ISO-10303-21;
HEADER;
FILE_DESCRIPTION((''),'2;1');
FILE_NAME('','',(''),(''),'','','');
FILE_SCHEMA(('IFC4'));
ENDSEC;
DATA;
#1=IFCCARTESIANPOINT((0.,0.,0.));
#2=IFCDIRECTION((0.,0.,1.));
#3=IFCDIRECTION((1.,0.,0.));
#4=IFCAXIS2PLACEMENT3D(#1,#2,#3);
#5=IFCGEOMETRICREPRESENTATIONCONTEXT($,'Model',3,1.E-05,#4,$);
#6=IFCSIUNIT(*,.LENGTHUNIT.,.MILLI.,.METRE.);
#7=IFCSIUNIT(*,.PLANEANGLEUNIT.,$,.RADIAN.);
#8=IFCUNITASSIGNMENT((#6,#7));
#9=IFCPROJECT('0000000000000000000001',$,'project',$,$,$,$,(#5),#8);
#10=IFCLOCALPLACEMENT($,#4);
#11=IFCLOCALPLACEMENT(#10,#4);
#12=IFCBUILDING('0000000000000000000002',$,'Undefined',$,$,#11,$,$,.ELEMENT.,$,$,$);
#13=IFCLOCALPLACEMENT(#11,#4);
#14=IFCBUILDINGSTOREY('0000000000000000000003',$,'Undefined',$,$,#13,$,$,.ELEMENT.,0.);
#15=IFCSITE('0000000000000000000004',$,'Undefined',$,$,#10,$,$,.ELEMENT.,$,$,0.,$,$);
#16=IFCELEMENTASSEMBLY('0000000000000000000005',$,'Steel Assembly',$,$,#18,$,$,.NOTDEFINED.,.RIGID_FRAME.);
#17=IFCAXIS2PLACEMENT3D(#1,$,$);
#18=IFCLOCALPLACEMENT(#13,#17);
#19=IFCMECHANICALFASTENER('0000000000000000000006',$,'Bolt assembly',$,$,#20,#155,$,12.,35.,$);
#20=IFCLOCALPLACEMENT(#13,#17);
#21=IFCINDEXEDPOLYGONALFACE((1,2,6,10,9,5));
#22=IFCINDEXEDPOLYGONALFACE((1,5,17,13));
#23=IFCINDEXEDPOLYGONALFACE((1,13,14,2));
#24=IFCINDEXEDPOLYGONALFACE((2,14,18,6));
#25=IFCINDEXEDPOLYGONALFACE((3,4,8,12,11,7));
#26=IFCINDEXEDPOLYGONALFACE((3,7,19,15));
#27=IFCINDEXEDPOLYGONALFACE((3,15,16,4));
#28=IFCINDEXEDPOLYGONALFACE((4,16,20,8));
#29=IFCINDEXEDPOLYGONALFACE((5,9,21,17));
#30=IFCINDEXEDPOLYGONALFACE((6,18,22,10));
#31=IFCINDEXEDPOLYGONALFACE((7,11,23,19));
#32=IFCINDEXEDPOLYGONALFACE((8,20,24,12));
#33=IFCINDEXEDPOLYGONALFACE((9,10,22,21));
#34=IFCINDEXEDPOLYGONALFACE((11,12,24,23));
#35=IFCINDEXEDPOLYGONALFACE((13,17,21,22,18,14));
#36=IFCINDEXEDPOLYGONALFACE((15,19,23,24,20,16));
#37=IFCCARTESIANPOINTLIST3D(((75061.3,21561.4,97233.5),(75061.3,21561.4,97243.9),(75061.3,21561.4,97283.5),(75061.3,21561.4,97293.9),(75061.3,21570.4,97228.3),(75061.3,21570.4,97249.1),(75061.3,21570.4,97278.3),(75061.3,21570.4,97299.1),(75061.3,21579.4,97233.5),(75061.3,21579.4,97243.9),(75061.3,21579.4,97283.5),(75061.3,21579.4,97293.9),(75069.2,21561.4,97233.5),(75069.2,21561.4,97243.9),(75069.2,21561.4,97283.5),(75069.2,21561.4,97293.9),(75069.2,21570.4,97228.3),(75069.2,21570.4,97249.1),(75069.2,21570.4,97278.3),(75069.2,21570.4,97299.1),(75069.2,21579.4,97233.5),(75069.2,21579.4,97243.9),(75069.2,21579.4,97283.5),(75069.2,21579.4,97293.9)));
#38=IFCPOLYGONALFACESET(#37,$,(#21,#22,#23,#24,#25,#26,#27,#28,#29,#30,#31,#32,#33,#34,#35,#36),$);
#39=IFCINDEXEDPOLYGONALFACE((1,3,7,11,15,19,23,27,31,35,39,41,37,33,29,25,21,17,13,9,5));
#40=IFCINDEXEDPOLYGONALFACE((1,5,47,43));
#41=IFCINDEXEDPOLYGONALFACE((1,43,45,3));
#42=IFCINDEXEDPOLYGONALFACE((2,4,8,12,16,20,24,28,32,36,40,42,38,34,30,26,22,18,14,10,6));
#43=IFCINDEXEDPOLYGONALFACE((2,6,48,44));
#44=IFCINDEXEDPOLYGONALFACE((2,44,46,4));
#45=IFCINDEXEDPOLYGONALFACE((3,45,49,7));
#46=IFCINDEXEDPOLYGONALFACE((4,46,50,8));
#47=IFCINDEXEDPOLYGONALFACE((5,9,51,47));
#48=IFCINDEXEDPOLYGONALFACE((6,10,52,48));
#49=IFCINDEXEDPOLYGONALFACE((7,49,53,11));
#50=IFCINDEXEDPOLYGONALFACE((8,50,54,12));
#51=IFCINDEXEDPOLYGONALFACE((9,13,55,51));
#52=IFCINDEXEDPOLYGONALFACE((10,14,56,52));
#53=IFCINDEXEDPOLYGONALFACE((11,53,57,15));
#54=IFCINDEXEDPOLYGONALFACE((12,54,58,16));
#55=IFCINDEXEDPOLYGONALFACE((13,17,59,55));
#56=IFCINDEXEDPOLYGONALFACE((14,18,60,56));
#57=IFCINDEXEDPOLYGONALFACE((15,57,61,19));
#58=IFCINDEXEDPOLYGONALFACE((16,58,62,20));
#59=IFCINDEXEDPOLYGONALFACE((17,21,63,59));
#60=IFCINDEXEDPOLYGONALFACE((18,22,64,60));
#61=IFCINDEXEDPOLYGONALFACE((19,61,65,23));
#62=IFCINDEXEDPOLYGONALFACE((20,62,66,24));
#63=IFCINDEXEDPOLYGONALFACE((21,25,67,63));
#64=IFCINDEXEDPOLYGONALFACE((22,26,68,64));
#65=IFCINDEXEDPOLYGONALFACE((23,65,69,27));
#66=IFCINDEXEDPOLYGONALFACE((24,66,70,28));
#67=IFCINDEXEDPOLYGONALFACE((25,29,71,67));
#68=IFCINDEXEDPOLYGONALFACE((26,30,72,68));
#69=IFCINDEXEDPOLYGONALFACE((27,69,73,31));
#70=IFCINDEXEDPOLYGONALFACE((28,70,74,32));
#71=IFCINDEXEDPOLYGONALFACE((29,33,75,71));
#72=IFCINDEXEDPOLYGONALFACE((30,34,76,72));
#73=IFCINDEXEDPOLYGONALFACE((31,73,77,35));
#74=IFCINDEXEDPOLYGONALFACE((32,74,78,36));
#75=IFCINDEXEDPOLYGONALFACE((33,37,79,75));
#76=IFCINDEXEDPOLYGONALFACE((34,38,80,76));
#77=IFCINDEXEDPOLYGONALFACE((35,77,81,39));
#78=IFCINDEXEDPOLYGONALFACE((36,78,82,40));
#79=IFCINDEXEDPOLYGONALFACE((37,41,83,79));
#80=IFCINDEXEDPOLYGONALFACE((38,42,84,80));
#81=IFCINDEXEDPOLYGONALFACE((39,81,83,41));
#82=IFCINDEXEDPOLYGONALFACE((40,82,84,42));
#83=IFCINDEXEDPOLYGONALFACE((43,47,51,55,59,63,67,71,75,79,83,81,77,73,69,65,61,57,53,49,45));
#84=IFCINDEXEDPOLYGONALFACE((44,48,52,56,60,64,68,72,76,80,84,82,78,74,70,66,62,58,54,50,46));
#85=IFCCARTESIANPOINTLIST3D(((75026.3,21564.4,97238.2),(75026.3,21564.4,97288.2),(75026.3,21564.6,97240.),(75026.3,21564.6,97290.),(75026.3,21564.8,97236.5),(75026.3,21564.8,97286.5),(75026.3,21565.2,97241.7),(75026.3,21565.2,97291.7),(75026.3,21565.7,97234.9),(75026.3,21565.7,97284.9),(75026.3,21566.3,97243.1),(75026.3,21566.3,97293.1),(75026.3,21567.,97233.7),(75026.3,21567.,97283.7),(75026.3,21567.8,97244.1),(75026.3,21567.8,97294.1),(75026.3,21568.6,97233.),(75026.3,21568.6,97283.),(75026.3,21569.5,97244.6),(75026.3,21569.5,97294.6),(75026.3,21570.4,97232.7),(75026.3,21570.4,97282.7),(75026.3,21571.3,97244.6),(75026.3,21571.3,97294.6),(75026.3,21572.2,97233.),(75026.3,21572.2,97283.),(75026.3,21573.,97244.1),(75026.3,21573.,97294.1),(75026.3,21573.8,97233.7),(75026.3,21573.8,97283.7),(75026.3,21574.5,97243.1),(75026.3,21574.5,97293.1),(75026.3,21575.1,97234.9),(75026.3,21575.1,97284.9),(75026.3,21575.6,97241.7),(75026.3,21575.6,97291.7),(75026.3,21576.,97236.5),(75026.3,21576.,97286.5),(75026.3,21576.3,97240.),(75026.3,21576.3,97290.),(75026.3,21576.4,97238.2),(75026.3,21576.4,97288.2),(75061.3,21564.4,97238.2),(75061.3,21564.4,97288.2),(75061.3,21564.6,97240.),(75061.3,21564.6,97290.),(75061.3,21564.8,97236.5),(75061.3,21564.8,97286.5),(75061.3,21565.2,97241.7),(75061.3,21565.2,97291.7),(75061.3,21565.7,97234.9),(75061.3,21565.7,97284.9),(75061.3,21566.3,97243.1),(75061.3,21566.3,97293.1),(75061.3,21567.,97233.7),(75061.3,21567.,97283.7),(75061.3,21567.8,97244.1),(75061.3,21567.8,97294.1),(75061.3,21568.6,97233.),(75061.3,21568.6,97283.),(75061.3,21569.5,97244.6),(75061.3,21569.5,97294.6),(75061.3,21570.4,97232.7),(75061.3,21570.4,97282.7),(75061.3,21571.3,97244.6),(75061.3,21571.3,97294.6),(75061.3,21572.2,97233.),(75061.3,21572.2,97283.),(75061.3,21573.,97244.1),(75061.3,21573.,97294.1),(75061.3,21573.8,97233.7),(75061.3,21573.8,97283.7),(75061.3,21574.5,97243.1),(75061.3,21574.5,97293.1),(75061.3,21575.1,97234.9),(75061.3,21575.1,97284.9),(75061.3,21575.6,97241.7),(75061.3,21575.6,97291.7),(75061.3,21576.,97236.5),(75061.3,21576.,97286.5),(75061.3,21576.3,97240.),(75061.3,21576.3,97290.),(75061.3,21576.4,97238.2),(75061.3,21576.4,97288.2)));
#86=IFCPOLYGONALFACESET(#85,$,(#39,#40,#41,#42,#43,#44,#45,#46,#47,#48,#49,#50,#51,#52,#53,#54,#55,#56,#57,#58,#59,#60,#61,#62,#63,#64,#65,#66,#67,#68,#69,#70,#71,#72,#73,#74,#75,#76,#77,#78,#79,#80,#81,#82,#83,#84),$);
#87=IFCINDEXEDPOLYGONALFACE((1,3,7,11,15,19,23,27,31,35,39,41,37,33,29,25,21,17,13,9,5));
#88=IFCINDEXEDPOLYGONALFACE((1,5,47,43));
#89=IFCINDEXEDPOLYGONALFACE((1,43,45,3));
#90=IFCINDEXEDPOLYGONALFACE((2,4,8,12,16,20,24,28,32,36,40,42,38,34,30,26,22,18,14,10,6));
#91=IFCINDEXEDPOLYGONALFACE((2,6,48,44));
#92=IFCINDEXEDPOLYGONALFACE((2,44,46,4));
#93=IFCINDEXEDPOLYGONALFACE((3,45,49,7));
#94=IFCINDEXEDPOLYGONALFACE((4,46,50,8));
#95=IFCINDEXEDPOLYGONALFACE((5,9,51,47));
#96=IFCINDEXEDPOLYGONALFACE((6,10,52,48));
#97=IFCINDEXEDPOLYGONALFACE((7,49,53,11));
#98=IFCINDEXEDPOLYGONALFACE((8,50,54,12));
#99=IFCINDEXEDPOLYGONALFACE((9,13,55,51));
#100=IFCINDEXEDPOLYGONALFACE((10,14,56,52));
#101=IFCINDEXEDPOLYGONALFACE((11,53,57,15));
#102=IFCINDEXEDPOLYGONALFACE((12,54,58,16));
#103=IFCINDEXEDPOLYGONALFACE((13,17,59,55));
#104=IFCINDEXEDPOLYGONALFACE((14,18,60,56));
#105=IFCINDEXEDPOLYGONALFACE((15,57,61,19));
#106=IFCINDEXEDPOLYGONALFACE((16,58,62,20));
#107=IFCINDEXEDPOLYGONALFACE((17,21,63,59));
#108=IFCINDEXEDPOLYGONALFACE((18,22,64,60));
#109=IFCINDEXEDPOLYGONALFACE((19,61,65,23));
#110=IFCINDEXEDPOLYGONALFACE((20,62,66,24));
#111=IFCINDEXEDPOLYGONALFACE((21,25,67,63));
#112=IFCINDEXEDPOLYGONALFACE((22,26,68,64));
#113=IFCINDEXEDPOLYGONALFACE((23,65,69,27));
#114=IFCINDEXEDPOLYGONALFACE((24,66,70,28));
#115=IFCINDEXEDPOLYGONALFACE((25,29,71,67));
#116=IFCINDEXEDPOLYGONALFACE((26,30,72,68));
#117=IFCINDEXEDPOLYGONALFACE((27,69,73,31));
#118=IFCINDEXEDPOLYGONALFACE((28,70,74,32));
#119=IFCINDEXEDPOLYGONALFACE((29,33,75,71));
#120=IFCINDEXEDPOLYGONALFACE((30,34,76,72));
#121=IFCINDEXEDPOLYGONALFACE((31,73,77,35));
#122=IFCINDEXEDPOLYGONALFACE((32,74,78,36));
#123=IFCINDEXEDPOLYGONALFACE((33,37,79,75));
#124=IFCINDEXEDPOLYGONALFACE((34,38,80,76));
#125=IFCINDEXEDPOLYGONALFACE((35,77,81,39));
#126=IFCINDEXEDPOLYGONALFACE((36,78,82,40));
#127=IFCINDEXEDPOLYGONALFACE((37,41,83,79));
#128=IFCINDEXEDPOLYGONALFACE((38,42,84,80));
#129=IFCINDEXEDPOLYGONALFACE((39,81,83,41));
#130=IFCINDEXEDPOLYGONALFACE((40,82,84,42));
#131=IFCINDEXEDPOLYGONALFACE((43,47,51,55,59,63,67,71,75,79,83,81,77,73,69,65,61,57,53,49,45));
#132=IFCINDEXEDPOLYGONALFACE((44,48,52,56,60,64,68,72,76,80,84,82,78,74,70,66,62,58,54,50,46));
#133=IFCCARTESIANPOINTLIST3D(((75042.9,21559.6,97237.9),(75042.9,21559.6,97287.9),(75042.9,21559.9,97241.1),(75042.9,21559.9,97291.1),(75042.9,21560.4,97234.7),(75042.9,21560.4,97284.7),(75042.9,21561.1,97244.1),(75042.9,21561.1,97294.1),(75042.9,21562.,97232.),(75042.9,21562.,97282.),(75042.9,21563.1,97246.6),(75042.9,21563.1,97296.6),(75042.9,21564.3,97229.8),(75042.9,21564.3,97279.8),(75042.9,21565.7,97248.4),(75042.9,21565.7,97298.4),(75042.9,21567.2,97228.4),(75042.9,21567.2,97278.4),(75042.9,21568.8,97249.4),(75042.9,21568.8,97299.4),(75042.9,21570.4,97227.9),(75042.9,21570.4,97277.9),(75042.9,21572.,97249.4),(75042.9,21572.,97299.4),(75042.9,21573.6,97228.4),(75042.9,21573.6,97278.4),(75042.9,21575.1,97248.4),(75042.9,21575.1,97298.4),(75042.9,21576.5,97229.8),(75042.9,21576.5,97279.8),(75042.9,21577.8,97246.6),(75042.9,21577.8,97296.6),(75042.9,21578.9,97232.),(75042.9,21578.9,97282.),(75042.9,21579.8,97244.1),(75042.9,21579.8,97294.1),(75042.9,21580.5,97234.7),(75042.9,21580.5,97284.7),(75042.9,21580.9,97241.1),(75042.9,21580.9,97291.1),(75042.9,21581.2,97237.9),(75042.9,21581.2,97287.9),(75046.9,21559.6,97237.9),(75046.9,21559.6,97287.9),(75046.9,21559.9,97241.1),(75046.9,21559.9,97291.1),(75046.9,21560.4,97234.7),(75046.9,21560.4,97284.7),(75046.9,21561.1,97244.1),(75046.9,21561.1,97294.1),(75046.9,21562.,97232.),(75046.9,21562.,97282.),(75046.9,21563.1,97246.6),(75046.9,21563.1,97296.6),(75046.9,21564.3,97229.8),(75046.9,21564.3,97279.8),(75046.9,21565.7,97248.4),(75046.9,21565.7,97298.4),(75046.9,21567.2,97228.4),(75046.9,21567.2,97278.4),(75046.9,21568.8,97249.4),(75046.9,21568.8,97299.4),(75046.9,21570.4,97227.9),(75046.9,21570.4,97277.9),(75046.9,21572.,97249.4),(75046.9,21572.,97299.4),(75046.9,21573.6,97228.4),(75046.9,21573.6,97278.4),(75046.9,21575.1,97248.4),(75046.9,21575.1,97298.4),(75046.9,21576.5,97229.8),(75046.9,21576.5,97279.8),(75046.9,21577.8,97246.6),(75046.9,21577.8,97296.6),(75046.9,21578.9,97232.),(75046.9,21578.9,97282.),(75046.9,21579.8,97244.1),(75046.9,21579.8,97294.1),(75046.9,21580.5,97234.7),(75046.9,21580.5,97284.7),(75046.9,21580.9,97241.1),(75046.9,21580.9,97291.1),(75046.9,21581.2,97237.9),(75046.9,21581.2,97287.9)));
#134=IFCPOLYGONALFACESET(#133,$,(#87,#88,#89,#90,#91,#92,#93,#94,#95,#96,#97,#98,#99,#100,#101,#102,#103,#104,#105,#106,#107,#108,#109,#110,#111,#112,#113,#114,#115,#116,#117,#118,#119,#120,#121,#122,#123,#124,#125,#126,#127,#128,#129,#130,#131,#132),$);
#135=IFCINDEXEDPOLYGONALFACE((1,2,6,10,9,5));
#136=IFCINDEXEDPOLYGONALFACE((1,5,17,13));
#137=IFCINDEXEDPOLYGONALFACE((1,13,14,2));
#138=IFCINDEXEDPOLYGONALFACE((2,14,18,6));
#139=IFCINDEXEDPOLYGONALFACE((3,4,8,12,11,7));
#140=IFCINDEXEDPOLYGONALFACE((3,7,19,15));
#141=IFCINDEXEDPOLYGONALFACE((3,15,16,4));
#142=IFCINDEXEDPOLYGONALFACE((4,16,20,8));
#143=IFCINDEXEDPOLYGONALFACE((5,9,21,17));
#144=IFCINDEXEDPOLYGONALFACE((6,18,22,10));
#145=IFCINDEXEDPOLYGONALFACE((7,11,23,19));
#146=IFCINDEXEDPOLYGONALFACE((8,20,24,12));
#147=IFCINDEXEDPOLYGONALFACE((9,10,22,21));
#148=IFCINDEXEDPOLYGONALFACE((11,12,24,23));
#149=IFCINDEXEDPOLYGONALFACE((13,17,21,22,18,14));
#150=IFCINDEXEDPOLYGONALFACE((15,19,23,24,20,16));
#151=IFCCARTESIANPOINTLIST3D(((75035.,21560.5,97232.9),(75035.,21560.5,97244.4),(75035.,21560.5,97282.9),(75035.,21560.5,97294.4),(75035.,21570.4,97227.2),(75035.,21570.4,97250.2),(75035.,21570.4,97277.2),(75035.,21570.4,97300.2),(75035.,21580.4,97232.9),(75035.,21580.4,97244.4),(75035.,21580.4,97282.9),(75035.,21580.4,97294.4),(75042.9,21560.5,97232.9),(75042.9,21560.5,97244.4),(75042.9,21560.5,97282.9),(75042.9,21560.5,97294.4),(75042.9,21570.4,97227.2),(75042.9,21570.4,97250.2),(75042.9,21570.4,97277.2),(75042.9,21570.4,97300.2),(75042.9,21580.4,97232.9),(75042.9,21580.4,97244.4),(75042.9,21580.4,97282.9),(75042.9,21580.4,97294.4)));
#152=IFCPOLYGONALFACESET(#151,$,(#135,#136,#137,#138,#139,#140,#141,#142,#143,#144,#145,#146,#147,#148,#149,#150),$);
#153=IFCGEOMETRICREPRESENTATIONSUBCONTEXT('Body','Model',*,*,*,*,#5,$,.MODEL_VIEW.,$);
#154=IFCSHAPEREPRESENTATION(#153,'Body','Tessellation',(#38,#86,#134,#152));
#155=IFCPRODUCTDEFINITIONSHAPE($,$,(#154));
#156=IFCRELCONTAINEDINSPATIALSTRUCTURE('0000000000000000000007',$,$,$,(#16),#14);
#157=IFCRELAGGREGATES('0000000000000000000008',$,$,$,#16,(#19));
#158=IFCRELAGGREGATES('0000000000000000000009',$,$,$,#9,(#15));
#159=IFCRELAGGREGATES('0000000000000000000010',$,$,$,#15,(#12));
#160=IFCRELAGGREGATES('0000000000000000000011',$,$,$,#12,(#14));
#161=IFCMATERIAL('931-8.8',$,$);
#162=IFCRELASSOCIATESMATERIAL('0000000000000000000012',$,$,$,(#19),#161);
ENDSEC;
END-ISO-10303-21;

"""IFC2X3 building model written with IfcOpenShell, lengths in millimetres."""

from ifc_helpers import new_model, si_unit, frame, origin_with_axes, origin_2d_with_axis, place, context, subcontext, project, spatial, polyline, circle, outline, extrude, source, transform, mapped, material, element, aggregate, save


model = new_model("IFC2X3")

# Units and contexts
model_context = context("Model", 3, precision=1e-05, world=origin_with_axes())
body_context = subcontext(model_context, "Body", "Model", "MODEL_VIEW")
ifc_project = project(units=[si_unit("LENGTHUNIT", "METRE", prefix="MILLI"), si_unit("PLANEANGLEUNIT", "RADIAN")], contexts=[model_context])

# Site, building, storey
site_placement = place(None, origin_with_axes())
site = spatial("IfcSite", under=ifc_project, at=site_placement, Name="Undefined", CompositionType="ELEMENT", RefElevation=0.0)
building_placement = place(site_placement, origin_with_axes())
building = spatial("IfcBuilding", under=site, at=building_placement, Name="Undefined", CompositionType="ELEMENT")
storey_placement = place(building_placement, origin_with_axes())
storey = spatial("IfcBuildingStorey", under=building, at=storey_placement, Name="Undefined", CompositionType="ELEMENT", Elevation=0.0)

# Shared definitions
ifc_material_1 = material(Name="931-8.8")

# Element assembly
shared_shape_1 = source(origin_with_axes(), body_context, "Body", "SweptSolid", [
    extrude(outline(polyline([(10.4, 0.0), (5.2, 9.0), (-5.2, 9.0), (-10.4, 0.0), (-5.2, -9.0), (5.2, -9.0), (10.4, 0.0)])), frame((0.0, -22.3, 0.0), z_axis=(0.0, 1.0, 0.0), x_axis=(1.0, 0.0, 0.0)), (0.0, 0.0, 1.0), 7.9),
    extrude(circle(Radius=6.0, at=origin_2d_with_axis()), frame((0.0, -14.4, 0.0), z_axis=(0.0, 1.0, 0.0), x_axis=(1.0, 0.0, 0.0)), (0.0, 0.0, 1.0), 35.0),
    extrude(circle(Radius=10.8, at=origin_2d_with_axis()), frame((0.0, 0.0, 0.0), z_axis=(0.0, 1.0, 0.0), x_axis=(1.0, 0.0, 0.0)), (0.0, 0.0, 1.0), 4.0),
    extrude(outline(polyline([(11.5, 0.0), (5.8, 10.0), (-5.8, 10.0), (-11.5, 0.0), (-5.8, -10.0), (5.8, -10.0), (11.5, 0.0)])), frame((0.0, 4.0, 0.0), z_axis=(0.0, 1.0, 0.0), x_axis=(1.0, 0.0, 0.0)), (0.0, 0.0, 1.0), 7.9),
])
assembly_1_placement = place(storey_placement, origin_with_axes())
assembly_1 = element("IfcElementAssembly", 1, at=assembly_1_placement, inside=storey, Name="Steel Assembly", AssemblyPlace="NOTDEFINED", PredefinedType="RIGID_FRAME")

# Mechanical fastener
mechanical_fastener_1_placement = place(assembly_1_placement, frame((75046.9, 21570.4, 97288.7), z_axis=(0.0, 1.0, 0.0), x_axis=(0.0, 0.0, -1.0)))
mechanical_fastener_1 = element("IfcMechanicalFastener", 2, at=mechanical_fastener_1_placement, material=ifc_material_1, Name="Bolt assembly", NominalDiameter=12.0, NominalLength=35.0, context=body_context, shape_type="MappedRepresentation", body=[
    mapped(shared_shape_1, transform((0.0, 0.0, 0.0))),
    mapped(shared_shape_1, transform((50.0, 0.0, 0.0))),
])

aggregate(assembly_1, [mechanical_fastener_1])

save(model, "model.ifc")
